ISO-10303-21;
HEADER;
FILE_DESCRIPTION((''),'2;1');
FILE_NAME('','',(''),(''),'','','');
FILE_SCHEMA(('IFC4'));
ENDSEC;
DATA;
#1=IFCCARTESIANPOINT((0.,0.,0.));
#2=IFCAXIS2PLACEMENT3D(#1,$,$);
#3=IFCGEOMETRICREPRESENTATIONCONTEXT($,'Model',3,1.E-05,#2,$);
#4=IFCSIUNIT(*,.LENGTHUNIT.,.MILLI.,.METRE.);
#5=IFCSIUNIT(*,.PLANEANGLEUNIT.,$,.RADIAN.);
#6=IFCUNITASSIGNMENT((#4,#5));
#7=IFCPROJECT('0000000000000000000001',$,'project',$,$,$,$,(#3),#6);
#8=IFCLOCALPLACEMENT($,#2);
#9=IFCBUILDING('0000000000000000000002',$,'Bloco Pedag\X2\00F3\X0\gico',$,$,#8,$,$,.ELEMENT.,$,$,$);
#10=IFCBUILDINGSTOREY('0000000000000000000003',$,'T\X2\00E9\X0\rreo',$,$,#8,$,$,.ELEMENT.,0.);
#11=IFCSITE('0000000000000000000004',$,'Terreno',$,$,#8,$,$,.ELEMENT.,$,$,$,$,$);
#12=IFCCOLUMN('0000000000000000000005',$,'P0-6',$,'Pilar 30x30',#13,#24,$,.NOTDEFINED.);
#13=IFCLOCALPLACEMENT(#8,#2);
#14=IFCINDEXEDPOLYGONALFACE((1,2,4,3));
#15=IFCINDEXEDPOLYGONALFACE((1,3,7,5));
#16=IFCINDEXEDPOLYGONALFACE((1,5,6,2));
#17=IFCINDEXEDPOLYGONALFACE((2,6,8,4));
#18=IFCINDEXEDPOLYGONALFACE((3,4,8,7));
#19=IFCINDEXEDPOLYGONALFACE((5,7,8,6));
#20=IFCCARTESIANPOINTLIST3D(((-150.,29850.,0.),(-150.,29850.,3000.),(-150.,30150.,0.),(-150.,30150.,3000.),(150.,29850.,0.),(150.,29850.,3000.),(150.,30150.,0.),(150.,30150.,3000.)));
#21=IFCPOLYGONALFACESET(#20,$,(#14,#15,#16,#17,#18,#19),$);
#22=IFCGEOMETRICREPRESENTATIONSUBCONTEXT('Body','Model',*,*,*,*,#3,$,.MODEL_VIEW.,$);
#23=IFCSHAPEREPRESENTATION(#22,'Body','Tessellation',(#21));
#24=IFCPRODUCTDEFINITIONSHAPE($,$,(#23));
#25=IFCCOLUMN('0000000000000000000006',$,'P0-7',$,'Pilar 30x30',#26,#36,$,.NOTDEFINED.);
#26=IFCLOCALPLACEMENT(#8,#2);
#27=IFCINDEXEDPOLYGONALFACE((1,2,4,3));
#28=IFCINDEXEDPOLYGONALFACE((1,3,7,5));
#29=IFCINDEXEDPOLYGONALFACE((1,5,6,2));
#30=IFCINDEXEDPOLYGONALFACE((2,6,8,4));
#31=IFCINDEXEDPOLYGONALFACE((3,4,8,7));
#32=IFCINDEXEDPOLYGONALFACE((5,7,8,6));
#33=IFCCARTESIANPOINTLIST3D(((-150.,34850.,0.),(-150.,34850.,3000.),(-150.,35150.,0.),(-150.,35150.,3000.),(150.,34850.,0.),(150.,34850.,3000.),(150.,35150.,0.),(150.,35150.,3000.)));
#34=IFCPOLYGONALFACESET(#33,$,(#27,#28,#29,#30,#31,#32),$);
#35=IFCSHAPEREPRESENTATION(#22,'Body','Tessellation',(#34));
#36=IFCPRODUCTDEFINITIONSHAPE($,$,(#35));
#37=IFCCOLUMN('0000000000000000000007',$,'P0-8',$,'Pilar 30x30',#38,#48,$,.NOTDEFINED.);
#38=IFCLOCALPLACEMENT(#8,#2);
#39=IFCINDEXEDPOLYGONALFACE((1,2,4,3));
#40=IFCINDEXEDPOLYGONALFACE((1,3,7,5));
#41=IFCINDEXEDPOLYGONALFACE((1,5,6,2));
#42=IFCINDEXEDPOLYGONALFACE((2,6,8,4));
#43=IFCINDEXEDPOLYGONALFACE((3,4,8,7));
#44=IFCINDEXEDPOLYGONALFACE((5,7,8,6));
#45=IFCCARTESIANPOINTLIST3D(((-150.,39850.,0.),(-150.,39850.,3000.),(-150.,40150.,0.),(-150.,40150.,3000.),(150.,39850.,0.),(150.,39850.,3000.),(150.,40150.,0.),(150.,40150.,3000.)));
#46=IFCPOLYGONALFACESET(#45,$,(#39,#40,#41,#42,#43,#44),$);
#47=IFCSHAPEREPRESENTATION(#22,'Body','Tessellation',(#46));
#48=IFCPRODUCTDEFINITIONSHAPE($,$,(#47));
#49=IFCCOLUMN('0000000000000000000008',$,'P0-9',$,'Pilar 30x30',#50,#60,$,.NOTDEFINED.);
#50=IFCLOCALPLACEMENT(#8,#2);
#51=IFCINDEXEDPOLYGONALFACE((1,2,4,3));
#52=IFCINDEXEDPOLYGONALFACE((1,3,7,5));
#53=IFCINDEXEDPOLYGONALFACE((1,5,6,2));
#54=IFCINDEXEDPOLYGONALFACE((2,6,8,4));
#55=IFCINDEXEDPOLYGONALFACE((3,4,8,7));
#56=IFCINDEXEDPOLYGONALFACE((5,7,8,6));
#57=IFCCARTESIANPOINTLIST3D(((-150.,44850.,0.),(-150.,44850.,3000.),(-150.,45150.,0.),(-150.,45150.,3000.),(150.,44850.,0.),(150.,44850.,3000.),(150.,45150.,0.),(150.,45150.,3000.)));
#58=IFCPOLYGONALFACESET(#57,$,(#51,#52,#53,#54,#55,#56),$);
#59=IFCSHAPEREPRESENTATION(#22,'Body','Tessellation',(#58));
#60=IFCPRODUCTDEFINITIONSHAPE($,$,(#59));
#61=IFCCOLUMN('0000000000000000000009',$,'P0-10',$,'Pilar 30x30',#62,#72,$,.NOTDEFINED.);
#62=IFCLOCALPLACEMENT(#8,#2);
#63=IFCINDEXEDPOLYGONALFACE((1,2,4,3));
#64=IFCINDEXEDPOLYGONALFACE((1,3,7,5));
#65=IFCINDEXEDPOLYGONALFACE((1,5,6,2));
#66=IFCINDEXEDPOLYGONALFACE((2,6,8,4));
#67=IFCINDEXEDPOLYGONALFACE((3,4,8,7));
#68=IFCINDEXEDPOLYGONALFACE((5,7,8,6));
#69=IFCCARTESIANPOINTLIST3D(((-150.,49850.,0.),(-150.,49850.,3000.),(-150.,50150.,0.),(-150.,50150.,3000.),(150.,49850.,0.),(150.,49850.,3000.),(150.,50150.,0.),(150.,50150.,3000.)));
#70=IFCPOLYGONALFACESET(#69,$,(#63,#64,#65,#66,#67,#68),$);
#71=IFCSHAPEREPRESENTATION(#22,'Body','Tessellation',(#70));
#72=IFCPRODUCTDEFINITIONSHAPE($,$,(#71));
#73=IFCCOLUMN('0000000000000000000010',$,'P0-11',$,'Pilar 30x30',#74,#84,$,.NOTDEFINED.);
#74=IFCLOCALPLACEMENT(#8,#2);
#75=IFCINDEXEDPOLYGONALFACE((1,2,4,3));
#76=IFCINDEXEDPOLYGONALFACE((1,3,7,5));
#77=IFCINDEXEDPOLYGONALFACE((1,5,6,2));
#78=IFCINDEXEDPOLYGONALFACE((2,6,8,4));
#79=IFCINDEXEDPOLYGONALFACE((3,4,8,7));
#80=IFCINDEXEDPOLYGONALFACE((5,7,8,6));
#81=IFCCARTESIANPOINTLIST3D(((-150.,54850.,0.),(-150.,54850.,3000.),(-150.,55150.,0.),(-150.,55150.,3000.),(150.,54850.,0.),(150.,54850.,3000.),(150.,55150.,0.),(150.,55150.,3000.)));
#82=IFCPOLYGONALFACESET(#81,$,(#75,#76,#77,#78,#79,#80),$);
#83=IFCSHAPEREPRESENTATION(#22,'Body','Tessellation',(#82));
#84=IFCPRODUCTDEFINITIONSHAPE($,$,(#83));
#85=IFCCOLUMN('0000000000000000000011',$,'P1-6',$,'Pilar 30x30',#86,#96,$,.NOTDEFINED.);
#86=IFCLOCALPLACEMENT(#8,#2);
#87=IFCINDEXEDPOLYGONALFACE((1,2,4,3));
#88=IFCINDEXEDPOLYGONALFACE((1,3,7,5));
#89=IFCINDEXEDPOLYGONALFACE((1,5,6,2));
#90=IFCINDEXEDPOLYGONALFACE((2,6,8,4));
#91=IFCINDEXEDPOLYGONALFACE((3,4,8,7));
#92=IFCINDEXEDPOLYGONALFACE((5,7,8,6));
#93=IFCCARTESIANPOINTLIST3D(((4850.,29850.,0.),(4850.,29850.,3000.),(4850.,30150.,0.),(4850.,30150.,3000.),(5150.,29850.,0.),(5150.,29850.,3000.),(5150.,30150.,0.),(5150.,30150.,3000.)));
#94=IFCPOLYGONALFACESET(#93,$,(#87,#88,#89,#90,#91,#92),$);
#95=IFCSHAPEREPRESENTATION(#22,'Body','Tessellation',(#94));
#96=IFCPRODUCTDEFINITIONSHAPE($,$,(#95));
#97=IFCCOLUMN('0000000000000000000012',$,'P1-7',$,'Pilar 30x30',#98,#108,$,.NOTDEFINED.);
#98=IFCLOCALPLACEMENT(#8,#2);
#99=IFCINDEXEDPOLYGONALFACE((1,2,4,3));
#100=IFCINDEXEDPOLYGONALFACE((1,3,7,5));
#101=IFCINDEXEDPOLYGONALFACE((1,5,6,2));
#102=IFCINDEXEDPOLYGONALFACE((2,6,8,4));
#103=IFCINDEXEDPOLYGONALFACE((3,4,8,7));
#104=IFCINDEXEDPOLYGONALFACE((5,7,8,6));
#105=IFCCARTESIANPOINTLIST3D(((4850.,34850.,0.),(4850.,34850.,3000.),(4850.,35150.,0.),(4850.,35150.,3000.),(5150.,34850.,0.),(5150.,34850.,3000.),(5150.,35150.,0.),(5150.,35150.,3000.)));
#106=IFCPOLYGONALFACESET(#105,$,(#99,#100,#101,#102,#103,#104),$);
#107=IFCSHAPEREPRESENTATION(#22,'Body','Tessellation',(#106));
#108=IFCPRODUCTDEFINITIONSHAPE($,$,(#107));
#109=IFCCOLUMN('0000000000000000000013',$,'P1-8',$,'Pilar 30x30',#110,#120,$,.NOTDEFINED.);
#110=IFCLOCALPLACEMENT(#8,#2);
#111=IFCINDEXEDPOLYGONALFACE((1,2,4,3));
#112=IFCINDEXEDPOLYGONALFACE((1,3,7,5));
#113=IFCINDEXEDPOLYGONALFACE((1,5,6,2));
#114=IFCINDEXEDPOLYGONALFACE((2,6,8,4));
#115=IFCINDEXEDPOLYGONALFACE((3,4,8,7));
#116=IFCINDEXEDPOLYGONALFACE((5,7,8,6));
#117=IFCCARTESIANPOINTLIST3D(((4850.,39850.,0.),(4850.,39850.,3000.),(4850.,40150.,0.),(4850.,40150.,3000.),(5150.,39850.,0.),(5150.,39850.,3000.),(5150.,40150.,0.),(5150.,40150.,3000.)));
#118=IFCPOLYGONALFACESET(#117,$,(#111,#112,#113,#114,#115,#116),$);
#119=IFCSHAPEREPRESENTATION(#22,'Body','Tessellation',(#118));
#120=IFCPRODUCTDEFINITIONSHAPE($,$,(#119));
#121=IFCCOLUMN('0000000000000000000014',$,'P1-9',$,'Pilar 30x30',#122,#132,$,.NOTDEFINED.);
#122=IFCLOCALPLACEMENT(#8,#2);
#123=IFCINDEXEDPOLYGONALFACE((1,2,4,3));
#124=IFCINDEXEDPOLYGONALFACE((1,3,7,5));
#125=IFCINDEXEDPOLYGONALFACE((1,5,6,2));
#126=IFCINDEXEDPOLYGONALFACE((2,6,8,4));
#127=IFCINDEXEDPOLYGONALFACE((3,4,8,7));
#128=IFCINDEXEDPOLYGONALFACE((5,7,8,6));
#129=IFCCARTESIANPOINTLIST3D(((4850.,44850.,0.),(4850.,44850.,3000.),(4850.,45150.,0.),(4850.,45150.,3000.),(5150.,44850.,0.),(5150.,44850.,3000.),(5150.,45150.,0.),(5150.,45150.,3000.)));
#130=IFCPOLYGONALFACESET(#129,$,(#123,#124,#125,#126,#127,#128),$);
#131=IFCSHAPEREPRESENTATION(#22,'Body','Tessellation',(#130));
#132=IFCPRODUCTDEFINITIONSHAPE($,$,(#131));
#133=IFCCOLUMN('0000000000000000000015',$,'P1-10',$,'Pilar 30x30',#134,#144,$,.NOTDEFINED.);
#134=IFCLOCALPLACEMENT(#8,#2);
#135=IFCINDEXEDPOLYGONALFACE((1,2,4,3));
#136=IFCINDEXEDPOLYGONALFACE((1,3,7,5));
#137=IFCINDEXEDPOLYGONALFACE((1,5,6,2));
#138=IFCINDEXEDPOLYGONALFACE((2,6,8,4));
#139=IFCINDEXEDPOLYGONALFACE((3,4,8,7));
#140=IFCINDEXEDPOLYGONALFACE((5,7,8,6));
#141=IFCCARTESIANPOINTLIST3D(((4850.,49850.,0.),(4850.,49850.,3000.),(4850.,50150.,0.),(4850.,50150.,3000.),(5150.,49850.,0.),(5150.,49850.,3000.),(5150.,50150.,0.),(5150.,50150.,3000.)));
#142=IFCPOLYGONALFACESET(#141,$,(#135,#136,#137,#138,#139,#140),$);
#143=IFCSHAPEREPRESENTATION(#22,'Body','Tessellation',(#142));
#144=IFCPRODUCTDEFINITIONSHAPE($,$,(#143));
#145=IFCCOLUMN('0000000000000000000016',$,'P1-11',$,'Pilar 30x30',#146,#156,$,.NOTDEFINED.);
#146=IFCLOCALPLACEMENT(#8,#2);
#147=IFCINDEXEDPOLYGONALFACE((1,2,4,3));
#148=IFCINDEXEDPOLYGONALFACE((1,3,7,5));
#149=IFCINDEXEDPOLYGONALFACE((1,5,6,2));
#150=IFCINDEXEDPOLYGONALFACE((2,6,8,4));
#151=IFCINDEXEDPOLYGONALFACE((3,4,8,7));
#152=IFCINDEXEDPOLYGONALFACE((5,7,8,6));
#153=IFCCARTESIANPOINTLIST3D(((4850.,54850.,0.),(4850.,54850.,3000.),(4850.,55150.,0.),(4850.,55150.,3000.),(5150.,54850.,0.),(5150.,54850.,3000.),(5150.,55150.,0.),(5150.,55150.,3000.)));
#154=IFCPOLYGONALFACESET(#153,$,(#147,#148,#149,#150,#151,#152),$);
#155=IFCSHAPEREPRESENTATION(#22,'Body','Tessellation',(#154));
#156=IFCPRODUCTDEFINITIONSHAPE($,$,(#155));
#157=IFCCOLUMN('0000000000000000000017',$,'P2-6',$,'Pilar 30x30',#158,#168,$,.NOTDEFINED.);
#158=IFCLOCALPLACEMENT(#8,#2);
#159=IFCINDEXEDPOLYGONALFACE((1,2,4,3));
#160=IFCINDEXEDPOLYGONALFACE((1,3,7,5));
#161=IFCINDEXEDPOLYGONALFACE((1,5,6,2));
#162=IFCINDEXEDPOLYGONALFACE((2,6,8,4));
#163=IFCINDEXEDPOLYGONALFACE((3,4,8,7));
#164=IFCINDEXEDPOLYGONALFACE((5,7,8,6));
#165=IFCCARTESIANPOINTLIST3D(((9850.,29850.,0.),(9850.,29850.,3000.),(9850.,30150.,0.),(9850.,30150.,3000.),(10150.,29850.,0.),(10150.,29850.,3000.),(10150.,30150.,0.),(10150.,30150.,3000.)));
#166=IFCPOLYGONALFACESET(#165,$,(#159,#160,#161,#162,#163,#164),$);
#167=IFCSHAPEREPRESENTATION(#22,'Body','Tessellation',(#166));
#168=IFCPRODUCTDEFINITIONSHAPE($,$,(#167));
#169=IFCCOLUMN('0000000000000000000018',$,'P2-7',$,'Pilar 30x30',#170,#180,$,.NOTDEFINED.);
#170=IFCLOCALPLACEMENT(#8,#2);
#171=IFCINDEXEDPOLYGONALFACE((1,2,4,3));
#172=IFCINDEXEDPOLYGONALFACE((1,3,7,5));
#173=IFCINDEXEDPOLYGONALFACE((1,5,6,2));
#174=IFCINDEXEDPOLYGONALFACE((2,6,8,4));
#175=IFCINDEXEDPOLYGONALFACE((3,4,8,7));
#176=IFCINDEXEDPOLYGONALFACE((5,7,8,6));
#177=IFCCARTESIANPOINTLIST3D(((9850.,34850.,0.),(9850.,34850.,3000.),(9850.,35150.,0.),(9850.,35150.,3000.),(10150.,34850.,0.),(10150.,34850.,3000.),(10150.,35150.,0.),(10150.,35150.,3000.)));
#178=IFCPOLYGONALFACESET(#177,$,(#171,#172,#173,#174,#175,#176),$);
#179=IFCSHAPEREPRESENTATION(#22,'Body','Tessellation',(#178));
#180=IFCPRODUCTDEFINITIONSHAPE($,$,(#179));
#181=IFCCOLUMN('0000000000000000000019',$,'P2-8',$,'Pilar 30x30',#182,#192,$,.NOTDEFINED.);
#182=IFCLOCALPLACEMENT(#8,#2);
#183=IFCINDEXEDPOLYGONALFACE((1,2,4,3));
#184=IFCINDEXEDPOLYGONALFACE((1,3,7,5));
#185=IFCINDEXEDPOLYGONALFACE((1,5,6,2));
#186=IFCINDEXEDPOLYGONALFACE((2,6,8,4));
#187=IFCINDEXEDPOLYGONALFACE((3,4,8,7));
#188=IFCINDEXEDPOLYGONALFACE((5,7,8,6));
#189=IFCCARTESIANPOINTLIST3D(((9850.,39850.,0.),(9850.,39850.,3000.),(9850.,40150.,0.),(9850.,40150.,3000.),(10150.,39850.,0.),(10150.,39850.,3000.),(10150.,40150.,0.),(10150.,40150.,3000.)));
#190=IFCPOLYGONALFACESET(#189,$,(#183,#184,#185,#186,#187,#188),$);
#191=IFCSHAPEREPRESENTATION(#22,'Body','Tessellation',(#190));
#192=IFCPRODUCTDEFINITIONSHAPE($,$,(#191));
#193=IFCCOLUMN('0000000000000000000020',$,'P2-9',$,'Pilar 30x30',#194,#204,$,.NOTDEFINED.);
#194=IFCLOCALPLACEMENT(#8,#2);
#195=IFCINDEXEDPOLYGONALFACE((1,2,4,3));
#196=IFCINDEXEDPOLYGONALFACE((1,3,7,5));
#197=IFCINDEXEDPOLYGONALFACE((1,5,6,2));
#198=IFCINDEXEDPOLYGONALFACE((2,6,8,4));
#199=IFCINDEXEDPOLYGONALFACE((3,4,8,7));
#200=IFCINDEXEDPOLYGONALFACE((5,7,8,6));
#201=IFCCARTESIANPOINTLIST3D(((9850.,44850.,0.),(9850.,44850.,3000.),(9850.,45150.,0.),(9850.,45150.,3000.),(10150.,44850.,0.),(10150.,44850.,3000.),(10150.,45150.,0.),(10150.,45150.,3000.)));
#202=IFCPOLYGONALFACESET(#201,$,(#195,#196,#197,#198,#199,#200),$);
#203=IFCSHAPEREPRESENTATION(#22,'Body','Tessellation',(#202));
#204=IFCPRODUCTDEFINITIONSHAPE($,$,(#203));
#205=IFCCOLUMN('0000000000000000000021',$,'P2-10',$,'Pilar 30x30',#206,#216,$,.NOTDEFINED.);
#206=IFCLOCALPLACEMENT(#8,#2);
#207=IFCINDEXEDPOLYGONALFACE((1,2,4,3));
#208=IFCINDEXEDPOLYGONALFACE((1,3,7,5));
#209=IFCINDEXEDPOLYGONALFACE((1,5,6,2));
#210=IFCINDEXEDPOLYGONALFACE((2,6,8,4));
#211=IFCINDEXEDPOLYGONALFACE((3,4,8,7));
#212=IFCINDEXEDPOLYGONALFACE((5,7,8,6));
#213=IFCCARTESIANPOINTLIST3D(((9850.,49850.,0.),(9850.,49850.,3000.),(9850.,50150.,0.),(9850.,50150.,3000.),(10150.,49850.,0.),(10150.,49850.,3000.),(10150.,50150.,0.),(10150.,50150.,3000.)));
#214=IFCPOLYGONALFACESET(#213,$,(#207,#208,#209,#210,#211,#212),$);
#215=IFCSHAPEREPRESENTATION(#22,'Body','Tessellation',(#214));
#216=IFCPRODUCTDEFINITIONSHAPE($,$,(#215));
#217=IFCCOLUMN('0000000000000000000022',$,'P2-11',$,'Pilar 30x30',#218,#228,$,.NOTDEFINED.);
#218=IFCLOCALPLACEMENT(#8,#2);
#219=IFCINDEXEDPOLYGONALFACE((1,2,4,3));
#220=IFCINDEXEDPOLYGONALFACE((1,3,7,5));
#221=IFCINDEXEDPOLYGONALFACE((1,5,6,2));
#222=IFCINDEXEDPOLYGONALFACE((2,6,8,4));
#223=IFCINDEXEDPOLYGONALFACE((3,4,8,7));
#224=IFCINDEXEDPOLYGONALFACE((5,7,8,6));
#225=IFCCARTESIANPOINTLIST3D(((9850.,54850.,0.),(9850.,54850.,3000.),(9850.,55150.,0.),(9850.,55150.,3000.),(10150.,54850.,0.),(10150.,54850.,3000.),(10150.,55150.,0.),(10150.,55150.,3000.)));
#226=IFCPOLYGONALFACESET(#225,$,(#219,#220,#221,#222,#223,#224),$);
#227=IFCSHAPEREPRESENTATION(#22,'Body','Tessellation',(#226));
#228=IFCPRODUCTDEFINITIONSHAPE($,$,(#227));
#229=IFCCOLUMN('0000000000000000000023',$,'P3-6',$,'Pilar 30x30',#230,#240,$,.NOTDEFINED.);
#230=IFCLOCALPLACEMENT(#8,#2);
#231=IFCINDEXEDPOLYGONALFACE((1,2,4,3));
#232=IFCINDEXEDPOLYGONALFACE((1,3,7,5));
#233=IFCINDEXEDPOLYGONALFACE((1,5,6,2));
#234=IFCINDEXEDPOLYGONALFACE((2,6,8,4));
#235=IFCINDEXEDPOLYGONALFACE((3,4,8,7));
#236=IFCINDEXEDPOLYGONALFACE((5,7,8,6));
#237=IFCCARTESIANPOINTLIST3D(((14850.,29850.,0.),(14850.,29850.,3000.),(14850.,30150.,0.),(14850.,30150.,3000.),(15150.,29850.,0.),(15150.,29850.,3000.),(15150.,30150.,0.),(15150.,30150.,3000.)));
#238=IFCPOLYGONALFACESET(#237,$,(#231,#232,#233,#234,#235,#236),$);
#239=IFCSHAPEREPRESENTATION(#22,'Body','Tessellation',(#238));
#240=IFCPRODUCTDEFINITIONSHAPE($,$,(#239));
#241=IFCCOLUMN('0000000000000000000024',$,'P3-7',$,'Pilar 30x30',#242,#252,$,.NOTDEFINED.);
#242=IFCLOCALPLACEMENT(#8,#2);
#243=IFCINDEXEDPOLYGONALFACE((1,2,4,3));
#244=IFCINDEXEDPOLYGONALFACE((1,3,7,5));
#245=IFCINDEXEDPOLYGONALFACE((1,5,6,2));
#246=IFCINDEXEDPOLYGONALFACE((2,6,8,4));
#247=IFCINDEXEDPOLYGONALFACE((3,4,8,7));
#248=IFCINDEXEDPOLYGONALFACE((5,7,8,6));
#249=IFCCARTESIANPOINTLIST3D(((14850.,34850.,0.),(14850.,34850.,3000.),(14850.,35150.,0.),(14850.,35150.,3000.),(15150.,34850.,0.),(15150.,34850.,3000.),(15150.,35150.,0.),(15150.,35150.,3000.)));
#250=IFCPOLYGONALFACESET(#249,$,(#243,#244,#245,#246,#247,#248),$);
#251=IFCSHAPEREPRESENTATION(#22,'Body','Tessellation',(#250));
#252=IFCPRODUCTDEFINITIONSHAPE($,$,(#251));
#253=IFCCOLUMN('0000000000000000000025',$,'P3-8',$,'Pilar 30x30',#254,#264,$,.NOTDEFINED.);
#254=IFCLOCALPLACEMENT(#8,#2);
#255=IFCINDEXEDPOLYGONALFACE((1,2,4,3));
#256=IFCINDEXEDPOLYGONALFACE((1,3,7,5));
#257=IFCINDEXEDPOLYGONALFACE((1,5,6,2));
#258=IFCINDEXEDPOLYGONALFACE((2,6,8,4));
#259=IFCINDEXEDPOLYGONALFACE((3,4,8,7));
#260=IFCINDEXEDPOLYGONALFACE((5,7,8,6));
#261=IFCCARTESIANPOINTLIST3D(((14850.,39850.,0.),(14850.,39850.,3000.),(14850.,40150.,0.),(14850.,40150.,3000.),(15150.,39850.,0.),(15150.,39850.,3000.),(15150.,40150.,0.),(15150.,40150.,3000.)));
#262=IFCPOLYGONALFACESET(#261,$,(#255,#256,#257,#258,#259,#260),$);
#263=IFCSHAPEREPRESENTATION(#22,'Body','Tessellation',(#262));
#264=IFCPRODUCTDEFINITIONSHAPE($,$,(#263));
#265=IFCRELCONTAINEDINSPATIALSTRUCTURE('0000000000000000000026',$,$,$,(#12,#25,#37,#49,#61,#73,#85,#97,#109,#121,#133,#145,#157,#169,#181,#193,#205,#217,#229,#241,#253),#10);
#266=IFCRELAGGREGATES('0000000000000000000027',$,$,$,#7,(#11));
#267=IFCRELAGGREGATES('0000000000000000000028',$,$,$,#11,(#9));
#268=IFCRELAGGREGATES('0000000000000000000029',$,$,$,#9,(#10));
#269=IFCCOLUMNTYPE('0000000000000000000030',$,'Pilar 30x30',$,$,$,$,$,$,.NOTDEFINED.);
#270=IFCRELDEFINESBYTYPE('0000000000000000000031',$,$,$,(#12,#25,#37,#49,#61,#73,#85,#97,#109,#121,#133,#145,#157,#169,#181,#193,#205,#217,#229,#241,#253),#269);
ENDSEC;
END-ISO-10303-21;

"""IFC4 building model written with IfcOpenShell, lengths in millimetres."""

from ifc_helpers import new_model, si_unit, frame, origin, origin_2d, place, context, subcontext, project, spatial, rectangle, extrude, type_object, element, save


model = new_model("IFC4")

# Units and contexts
model_context = context("Model", 3, precision=1e-05, world=origin())
body_context = subcontext(model_context, "Body", "Model", "MODEL_VIEW")
ifc_project = project(units=[si_unit("LENGTHUNIT", "METRE", prefix="MILLI"), si_unit("PLANEANGLEUNIT", "RADIAN")], contexts=[model_context])

# Site, building, storey
placement = place(None, origin())
site = spatial("IfcSite", under=ifc_project, at=placement, Name="Terreno", CompositionType="ELEMENT")
building = spatial("IfcBuilding", under=site, at=placement, Name="Bloco Pedagógico", CompositionType="ELEMENT")
storey = spatial("IfcBuildingStorey", under=building, at=placement, Name="Térreo", CompositionType="ELEMENT", Elevation=0.0)

# Columns
column_type = type_object("IfcColumnType", Name="Pilar 30x30", PredefinedType="NOTDEFINED")
for number, where, z_axis, x_axis, name in (
    (1, (0.0, 30000.0, 0.0), (0.0, 0.0, 1.0), (1.0, 0.0, 0.0), "P0-6"),
    (2, (0.0, 35000.0, 0.0), (0.0, 0.0, 1.0), (1.0, 0.0, 0.0), "P0-7"),
    (3, (0.0, 40000.0, 0.0), (0.0, 0.0, 1.0), (1.0, 0.0, 0.0), "P0-8"),
    (4, (0.0, 45000.0, 0.0), (0.0, 0.0, 1.0), (1.0, 0.0, 0.0), "P0-9"),
    (5, (0.0, 50000.0, 0.0), (0.0, 0.0, 1.0), (1.0, 0.0, 0.0), "P0-10"),
    (6, (0.0, 55000.0, 0.0), (0.0, 0.0, 1.0), (1.0, 0.0, 0.0), "P0-11"),
    (7, (5000.0, 30000.0, 0.0), (0.0, 0.0, 1.0), (1.0, 0.0, 0.0), "P1-6"),
    (8, (5000.0, 35000.0, 0.0), (0.0, 0.0, 1.0), (1.0, 0.0, 0.0), "P1-7"),
    (9, (5000.0, 40000.0, 0.0), (0.0, 0.0, 1.0), (1.0, 0.0, 0.0), "P1-8"),
    (10, (5000.0, 45000.0, 0.0), (0.0, 0.0, 1.0), (1.0, 0.0, 0.0), "P1-9"),
    (11, (5000.0, 50000.0, 0.0), (0.0, 0.0, 1.0), (1.0, 0.0, 0.0), "P1-10"),
    (12, (5000.0, 55000.0, 0.0), (0.0, 0.0, 1.0), (1.0, 0.0, 0.0), "P1-11"),
    (13, (10000.0, 30000.0, 0.0), (0.0, 0.0, 1.0), (1.0, 0.0, 0.0), "P2-6"),
    (14, (10000.0, 35000.0, 0.0), (0.0, 0.0, 1.0), (1.0, 0.0, 0.0), "P2-7"),
    (15, (10000.0, 40000.0, 0.0), (0.0, 0.0, 1.0), (1.0, 0.0, 0.0), "P2-8"),
    (16, (10000.0, 45000.0, 0.0), (0.0, 0.0, 1.0), (1.0, 0.0, 0.0), "P2-9"),
    (17, (10000.0, 50000.0, 0.0), (0.0, 0.0, 1.0), (1.0, 0.0, 0.0), "P2-10"),
    (18, (10000.0, 55000.0, 0.0), (0.0, 0.0, 1.0), (1.0, 0.0, 0.0), "P2-11"),
    (19, (15000.0, 30000.0, 0.0), (0.0, 0.0, 1.0), (1.0, 0.0, 0.0), "P3-6"),
    (20, (15000.0, 35000.0, 0.0), (0.0, 0.0, 1.0), (1.0, 0.0, 0.0), "P3-7"),
    (21, (15000.0, 40000.0, 0.0), (0.0, 0.0, 1.0), (1.0, 0.0, 0.0), "P3-8"),
):
    element("IfcColumn", number, at=place(None, frame(where, z_axis=z_axis, x_axis=x_axis)), inside=storey, type_object=column_type, Name=name, ObjectType="Pilar 30x30", PredefinedType="NOTDEFINED", context=body_context, shape_type="SweptSolid", body=[
        extrude(rectangle(XDim=300.0, YDim=300.0, at=origin_2d()), None, (0.0, 0.0, 1.0), 3000.0),
    ])

save(model, "model.ifc")
